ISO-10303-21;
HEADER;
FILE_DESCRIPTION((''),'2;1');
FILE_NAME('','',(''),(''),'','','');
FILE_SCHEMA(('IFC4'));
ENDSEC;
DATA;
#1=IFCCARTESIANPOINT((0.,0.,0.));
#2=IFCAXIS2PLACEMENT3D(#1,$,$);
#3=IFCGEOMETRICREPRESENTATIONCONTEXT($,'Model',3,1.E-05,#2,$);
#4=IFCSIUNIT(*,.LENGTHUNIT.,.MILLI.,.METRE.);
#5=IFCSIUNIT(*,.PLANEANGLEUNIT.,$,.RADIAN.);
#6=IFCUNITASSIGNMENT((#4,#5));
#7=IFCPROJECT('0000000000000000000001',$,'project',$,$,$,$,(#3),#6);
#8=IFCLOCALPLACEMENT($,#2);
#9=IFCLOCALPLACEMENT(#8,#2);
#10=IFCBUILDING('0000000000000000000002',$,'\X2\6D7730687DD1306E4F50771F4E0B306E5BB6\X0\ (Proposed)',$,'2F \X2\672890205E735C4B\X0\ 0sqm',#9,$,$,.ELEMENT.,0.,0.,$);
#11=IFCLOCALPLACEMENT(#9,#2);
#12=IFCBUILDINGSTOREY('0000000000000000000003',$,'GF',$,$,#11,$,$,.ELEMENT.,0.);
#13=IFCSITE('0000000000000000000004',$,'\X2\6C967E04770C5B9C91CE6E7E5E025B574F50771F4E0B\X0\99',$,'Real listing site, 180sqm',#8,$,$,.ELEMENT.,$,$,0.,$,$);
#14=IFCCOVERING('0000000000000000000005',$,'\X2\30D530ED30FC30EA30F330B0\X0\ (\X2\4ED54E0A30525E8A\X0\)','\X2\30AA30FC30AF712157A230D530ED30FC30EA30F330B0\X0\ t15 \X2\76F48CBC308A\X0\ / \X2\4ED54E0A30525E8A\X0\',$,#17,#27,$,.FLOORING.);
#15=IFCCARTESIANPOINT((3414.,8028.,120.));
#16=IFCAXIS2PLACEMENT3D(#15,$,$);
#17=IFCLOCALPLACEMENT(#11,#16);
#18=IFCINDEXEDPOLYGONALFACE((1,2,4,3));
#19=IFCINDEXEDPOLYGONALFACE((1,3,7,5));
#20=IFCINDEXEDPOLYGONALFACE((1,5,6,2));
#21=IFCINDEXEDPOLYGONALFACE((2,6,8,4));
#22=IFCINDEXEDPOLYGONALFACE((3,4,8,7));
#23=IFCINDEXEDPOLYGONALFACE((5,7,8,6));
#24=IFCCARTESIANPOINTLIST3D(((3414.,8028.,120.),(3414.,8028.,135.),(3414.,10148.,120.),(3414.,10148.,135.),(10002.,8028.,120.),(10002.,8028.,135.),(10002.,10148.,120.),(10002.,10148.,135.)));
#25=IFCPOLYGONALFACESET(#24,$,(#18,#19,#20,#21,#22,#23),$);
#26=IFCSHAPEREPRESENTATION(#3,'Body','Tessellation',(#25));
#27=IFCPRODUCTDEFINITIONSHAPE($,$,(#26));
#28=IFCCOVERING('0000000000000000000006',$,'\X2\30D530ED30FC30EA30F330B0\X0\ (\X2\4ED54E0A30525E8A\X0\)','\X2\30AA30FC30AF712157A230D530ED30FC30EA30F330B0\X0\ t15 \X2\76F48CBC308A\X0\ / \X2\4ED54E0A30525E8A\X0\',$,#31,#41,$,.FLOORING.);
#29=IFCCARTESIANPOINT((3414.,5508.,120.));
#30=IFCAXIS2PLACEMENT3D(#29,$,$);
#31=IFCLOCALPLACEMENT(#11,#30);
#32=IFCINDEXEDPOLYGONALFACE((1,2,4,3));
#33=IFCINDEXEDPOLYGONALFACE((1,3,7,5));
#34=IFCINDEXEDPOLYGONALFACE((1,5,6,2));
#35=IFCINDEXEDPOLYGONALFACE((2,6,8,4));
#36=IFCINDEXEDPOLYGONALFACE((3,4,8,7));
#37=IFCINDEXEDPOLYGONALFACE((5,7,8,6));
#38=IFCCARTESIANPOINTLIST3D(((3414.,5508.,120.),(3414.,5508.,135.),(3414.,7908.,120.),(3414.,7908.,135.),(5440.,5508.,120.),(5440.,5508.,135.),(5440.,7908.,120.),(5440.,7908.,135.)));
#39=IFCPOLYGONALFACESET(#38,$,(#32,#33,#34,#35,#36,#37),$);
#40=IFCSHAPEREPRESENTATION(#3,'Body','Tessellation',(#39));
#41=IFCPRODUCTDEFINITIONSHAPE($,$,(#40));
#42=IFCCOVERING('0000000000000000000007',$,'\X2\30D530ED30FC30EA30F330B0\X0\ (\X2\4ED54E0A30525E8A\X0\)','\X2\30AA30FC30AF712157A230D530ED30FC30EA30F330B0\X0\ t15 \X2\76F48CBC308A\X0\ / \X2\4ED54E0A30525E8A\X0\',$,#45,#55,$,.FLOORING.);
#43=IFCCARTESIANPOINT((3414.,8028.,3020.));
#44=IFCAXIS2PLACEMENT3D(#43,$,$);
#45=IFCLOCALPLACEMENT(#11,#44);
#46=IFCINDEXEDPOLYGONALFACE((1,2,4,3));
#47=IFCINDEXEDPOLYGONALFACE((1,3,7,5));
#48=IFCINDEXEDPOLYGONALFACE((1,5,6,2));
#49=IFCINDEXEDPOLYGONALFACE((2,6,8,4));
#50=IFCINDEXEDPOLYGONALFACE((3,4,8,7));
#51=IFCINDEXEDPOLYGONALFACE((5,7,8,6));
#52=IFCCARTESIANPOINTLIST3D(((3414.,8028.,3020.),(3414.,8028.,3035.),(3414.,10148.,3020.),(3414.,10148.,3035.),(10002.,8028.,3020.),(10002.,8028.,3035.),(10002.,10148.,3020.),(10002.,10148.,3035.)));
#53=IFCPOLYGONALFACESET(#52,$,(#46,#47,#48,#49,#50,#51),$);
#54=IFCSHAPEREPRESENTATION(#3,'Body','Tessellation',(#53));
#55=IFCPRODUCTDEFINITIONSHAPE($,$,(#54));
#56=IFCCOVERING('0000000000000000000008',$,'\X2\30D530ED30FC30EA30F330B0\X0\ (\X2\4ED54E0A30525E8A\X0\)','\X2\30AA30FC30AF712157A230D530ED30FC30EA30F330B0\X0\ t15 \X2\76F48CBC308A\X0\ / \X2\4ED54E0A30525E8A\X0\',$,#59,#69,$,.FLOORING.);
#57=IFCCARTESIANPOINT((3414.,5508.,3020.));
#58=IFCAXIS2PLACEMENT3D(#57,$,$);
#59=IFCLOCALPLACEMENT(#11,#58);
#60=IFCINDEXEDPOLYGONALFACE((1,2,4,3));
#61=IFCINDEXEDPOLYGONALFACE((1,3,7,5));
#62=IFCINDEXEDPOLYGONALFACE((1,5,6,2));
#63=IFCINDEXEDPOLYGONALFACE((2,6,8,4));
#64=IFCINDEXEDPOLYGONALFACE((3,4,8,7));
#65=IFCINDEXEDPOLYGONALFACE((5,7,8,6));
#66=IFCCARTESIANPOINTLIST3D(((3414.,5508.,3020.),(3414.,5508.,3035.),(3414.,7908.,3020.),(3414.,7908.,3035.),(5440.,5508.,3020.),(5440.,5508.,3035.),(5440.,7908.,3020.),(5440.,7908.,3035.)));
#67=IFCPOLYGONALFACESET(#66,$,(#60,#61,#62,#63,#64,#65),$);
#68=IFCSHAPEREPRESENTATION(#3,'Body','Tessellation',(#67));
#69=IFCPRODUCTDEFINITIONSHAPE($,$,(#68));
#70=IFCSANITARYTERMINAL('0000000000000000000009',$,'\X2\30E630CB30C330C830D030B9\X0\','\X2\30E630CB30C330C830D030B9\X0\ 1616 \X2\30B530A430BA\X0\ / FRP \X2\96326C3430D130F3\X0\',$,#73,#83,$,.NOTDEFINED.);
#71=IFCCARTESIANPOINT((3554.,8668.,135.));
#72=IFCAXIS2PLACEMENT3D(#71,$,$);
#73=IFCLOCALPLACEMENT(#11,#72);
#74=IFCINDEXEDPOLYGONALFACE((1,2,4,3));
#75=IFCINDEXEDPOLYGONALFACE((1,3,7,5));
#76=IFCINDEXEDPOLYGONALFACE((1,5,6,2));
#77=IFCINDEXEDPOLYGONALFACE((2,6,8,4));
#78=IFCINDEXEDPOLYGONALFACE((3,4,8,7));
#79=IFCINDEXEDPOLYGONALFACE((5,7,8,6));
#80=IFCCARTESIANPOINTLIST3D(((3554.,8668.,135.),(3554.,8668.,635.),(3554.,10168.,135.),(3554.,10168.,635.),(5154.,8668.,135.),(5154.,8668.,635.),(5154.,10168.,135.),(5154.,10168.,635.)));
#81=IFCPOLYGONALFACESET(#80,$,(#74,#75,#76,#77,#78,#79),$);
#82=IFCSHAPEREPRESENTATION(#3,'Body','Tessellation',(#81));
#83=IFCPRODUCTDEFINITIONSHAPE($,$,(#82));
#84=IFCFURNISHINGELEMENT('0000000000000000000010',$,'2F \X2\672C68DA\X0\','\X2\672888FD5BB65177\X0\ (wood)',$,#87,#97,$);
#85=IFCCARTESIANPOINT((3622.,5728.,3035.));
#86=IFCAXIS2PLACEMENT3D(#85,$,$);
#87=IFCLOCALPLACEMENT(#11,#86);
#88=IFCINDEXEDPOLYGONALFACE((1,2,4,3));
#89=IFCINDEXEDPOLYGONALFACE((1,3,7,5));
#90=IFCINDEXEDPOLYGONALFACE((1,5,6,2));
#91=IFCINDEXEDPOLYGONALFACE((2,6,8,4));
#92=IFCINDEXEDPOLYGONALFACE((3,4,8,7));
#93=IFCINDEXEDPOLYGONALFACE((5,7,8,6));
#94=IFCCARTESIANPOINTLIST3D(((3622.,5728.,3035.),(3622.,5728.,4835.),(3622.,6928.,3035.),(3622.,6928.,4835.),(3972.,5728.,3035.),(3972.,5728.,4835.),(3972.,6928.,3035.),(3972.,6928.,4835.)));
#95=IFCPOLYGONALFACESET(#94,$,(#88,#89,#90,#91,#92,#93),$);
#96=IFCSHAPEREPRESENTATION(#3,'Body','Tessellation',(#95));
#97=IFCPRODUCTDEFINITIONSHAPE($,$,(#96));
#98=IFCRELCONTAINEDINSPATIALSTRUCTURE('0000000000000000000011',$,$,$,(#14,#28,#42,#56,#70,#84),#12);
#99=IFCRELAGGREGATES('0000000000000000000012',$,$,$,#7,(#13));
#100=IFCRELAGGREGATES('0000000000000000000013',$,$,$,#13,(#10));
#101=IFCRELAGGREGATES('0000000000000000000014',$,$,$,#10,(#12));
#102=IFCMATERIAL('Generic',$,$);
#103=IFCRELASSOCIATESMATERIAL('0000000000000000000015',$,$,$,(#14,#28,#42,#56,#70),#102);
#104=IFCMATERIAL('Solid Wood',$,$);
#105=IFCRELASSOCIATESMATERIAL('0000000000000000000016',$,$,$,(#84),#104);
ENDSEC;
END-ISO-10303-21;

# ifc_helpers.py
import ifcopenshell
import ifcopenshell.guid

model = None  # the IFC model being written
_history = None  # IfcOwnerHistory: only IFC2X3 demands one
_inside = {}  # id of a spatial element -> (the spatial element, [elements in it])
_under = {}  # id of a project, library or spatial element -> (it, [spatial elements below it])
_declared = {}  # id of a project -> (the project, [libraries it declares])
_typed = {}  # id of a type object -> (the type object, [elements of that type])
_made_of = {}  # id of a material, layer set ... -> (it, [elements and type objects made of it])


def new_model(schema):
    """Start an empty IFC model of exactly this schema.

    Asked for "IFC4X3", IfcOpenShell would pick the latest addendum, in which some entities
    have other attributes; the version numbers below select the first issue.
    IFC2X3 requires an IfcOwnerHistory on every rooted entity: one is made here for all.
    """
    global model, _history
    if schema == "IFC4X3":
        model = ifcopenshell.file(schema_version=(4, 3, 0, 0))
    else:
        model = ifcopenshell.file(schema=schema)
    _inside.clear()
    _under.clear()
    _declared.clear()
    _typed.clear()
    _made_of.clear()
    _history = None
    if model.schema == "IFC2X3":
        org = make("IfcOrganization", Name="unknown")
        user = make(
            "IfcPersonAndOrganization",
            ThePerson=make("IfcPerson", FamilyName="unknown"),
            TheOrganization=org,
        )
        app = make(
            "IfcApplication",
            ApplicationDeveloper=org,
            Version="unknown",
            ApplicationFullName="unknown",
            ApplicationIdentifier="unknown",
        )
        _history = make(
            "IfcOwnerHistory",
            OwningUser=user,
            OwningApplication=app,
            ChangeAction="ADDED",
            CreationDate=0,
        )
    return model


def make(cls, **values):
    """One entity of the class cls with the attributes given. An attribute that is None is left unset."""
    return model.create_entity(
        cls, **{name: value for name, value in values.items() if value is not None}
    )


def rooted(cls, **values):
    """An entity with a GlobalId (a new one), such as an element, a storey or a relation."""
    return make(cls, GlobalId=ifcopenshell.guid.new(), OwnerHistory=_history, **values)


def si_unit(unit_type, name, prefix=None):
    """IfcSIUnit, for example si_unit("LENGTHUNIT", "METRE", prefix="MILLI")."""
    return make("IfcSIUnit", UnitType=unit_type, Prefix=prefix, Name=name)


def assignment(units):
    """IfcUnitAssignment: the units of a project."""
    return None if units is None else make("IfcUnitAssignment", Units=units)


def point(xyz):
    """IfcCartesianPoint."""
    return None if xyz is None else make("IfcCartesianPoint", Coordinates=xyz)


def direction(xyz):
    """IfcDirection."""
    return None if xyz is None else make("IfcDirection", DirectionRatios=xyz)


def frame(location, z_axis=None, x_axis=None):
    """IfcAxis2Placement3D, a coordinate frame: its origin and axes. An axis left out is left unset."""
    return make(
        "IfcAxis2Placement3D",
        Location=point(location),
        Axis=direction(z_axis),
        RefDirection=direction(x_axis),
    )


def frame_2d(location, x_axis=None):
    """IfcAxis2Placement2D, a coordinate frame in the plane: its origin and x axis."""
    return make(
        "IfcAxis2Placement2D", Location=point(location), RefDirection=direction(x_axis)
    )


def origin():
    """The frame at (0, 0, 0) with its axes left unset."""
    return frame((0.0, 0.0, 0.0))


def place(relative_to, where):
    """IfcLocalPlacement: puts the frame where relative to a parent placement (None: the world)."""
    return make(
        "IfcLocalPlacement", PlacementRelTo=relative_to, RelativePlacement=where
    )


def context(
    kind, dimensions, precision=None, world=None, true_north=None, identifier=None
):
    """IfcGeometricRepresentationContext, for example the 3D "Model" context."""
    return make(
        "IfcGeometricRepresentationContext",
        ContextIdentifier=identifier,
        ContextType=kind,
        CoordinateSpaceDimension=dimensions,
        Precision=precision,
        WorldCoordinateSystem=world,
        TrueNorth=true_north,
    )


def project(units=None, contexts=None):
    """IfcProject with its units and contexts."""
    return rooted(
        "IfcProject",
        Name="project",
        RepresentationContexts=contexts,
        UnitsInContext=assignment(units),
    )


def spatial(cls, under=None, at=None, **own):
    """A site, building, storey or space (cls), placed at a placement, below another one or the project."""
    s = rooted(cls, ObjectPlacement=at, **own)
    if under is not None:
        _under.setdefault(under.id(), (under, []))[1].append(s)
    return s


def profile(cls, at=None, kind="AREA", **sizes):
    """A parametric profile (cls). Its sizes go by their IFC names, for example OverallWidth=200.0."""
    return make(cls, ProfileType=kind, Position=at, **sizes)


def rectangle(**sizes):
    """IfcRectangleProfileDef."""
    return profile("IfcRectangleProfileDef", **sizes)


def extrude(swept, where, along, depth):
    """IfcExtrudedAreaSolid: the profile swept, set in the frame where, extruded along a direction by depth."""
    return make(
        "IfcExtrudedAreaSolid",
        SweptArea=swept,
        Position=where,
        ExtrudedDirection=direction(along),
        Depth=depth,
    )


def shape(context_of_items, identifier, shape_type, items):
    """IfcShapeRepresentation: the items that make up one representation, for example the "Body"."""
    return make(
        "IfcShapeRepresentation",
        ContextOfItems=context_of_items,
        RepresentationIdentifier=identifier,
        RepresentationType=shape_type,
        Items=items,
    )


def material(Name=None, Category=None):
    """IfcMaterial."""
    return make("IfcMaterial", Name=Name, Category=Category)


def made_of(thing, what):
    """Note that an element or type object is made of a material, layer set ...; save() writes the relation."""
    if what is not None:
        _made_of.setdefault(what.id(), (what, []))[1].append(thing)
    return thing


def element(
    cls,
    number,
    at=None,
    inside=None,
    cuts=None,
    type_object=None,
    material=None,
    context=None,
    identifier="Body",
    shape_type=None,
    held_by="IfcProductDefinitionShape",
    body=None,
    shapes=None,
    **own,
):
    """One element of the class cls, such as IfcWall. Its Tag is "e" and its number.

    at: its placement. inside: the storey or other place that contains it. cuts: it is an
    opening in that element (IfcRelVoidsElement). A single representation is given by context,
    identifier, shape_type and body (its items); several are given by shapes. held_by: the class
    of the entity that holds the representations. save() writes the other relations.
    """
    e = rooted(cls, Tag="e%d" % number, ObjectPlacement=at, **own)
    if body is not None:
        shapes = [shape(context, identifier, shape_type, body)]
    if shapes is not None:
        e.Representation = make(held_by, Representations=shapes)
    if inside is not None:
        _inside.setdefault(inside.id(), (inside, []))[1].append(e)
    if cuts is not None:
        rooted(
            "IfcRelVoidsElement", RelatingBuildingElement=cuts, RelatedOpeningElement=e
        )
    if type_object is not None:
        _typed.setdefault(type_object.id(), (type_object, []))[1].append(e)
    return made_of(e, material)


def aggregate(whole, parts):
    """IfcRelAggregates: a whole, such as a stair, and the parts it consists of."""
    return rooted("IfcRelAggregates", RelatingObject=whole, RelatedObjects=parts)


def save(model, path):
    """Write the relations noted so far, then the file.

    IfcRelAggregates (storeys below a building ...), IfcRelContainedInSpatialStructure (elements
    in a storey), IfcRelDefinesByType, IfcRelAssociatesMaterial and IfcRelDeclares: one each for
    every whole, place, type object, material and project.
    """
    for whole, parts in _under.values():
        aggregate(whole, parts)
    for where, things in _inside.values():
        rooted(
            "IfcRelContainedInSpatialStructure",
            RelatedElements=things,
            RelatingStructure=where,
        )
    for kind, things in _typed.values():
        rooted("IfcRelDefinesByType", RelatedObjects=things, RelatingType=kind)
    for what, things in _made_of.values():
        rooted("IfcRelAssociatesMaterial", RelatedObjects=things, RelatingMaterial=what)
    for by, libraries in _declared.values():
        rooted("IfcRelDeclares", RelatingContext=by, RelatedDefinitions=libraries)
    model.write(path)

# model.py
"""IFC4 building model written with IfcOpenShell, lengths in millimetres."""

from ifc_helpers import new_model, si_unit, frame, frame_2d, origin, place, context, project, spatial, rectangle, extrude, material, element, save


model = new_model("IFC4")

# Units and contexts
model_context = context("Model", 3, precision=1e-05, world=origin())
ifc_project = project(units=[si_unit("LENGTHUNIT", "METRE", prefix="MILLI"), si_unit("PLANEANGLEUNIT", "RADIAN")], contexts=[model_context])

# Site, building, storey
site_placement = place(None, origin())
site = spatial("IfcSite", under=ifc_project, at=site_placement, Name="沖縄県宜野湾市字佐真下99", ObjectType="Real listing site, 180sqm", CompositionType="ELEMENT", RefElevation=0.0)
building_placement = place(site_placement, origin())
building = spatial("IfcBuilding", under=site, at=building_placement, Name="海と緑の佐真下の家 (Proposed)", ObjectType="2F 木造平屋 0sqm", CompositionType="ELEMENT", ElevationOfRefHeight=0.0, ElevationOfTerrain=0.0)
storey_placement = place(building_placement, origin())
storey = spatial("IfcBuildingStorey", under=building, at=storey_placement, Name="GF", CompositionType="ELEMENT", Elevation=0.0)

# Shared definitions
ifc_material_1 = material(Name="Solid Wood")

# Coverings
ifc_material_2 = material(Name="Generic")
covering_1_placement = place(storey_placement, frame((3414.0, 8028.0, 120.0)))
element("IfcCovering", 1, at=covering_1_placement, inside=storey, material=ifc_material_2, Name="フローリング (仕上げ床)", Description="オーク無垢フローリング t15 直貼り / 仕上げ床", PredefinedType="FLOORING", context=model_context, shape_type="SweptSolid", body=[
    extrude(rectangle(XDim=6588.0, YDim=2120.0, at=frame_2d((3294.0, 1060.0))), frame((3414.0, 8028.0, 120.0)), (0.0, 0.0, 1.0), 15.0),
])
covering_2_placement = place(storey_placement, frame((3414.0, 5508.0, 120.0)))
element("IfcCovering", 2, at=covering_2_placement, inside=storey, material=ifc_material_2, Name="フローリング (仕上げ床)", Description="オーク無垢フローリング t15 直貼り / 仕上げ床", PredefinedType="FLOORING", context=model_context, shape_type="SweptSolid", body=[
    extrude(rectangle(XDim=2026.0, YDim=2400.0, at=frame_2d((1013.0, 1200.0))), frame((3414.0, 5508.0, 120.0)), (0.0, 0.0, 1.0), 15.0),
])
covering_3_placement = place(storey_placement, frame((3414.0, 8028.0, 3020.0)))
element("IfcCovering", 3, at=covering_3_placement, inside=storey, material=ifc_material_2, Name="フローリング (仕上げ床)", Description="オーク無垢フローリング t15 直貼り / 仕上げ床", PredefinedType="FLOORING", context=model_context, shape_type="SweptSolid", body=[
    extrude(rectangle(XDim=6588.0, YDim=2120.0, at=frame_2d((3294.0, 1060.0))), frame((3414.0, 8028.0, 3020.0)), (0.0, 0.0, 1.0), 15.0),
])
covering_4_placement = place(storey_placement, frame((3414.0, 5508.0, 3020.0)))
element("IfcCovering", 4, at=covering_4_placement, inside=storey, material=ifc_material_2, Name="フローリング (仕上げ床)", Description="オーク無垢フローリング t15 直貼り / 仕上げ床", PredefinedType="FLOORING", context=model_context, shape_type="SweptSolid", body=[
    extrude(rectangle(XDim=2026.0, YDim=2400.0, at=frame_2d((1013.0, 1200.0))), frame((3414.0, 5508.0, 3020.0)), (0.0, 0.0, 1.0), 15.0),
])

# Sanitary terminal
sanitary_terminal_placement = place(storey_placement, frame((3554.0, 8668.0, 135.0)))
element("IfcSanitaryTerminal", 5, at=sanitary_terminal_placement, inside=storey, material=ifc_material_2, Name="ユニットバス", Description="ユニットバス 1616 サイズ / FRP 防水パン", PredefinedType="NOTDEFINED", context=model_context, shape_type="SweptSolid", body=[
    extrude(rectangle(XDim=1600.0, YDim=1500.0, at=frame_2d((800.0, 750.0))), frame((3554.0, 8668.0, 135.0)), (0.0, 0.0, 1.0), 500.0),
])

# Furnishing element
furnishing_placement = place(storey_placement, frame((3622.0, 5728.0, 3035.0)))
element("IfcFurnishingElement", 6, at=furnishing_placement, inside=storey, material=ifc_material_1, Name="2F 本棚", Description="木製家具 (wood)", context=model_context, shape_type="SweptSolid", body=[
    extrude(rectangle(XDim=350.0, YDim=1200.0, at=frame_2d((175.0, 600.0))), frame((3622.0, 5728.0, 3035.0)), (0.0, 0.0, 1.0), 1800.0),
])

save(model, "model.ifc")
